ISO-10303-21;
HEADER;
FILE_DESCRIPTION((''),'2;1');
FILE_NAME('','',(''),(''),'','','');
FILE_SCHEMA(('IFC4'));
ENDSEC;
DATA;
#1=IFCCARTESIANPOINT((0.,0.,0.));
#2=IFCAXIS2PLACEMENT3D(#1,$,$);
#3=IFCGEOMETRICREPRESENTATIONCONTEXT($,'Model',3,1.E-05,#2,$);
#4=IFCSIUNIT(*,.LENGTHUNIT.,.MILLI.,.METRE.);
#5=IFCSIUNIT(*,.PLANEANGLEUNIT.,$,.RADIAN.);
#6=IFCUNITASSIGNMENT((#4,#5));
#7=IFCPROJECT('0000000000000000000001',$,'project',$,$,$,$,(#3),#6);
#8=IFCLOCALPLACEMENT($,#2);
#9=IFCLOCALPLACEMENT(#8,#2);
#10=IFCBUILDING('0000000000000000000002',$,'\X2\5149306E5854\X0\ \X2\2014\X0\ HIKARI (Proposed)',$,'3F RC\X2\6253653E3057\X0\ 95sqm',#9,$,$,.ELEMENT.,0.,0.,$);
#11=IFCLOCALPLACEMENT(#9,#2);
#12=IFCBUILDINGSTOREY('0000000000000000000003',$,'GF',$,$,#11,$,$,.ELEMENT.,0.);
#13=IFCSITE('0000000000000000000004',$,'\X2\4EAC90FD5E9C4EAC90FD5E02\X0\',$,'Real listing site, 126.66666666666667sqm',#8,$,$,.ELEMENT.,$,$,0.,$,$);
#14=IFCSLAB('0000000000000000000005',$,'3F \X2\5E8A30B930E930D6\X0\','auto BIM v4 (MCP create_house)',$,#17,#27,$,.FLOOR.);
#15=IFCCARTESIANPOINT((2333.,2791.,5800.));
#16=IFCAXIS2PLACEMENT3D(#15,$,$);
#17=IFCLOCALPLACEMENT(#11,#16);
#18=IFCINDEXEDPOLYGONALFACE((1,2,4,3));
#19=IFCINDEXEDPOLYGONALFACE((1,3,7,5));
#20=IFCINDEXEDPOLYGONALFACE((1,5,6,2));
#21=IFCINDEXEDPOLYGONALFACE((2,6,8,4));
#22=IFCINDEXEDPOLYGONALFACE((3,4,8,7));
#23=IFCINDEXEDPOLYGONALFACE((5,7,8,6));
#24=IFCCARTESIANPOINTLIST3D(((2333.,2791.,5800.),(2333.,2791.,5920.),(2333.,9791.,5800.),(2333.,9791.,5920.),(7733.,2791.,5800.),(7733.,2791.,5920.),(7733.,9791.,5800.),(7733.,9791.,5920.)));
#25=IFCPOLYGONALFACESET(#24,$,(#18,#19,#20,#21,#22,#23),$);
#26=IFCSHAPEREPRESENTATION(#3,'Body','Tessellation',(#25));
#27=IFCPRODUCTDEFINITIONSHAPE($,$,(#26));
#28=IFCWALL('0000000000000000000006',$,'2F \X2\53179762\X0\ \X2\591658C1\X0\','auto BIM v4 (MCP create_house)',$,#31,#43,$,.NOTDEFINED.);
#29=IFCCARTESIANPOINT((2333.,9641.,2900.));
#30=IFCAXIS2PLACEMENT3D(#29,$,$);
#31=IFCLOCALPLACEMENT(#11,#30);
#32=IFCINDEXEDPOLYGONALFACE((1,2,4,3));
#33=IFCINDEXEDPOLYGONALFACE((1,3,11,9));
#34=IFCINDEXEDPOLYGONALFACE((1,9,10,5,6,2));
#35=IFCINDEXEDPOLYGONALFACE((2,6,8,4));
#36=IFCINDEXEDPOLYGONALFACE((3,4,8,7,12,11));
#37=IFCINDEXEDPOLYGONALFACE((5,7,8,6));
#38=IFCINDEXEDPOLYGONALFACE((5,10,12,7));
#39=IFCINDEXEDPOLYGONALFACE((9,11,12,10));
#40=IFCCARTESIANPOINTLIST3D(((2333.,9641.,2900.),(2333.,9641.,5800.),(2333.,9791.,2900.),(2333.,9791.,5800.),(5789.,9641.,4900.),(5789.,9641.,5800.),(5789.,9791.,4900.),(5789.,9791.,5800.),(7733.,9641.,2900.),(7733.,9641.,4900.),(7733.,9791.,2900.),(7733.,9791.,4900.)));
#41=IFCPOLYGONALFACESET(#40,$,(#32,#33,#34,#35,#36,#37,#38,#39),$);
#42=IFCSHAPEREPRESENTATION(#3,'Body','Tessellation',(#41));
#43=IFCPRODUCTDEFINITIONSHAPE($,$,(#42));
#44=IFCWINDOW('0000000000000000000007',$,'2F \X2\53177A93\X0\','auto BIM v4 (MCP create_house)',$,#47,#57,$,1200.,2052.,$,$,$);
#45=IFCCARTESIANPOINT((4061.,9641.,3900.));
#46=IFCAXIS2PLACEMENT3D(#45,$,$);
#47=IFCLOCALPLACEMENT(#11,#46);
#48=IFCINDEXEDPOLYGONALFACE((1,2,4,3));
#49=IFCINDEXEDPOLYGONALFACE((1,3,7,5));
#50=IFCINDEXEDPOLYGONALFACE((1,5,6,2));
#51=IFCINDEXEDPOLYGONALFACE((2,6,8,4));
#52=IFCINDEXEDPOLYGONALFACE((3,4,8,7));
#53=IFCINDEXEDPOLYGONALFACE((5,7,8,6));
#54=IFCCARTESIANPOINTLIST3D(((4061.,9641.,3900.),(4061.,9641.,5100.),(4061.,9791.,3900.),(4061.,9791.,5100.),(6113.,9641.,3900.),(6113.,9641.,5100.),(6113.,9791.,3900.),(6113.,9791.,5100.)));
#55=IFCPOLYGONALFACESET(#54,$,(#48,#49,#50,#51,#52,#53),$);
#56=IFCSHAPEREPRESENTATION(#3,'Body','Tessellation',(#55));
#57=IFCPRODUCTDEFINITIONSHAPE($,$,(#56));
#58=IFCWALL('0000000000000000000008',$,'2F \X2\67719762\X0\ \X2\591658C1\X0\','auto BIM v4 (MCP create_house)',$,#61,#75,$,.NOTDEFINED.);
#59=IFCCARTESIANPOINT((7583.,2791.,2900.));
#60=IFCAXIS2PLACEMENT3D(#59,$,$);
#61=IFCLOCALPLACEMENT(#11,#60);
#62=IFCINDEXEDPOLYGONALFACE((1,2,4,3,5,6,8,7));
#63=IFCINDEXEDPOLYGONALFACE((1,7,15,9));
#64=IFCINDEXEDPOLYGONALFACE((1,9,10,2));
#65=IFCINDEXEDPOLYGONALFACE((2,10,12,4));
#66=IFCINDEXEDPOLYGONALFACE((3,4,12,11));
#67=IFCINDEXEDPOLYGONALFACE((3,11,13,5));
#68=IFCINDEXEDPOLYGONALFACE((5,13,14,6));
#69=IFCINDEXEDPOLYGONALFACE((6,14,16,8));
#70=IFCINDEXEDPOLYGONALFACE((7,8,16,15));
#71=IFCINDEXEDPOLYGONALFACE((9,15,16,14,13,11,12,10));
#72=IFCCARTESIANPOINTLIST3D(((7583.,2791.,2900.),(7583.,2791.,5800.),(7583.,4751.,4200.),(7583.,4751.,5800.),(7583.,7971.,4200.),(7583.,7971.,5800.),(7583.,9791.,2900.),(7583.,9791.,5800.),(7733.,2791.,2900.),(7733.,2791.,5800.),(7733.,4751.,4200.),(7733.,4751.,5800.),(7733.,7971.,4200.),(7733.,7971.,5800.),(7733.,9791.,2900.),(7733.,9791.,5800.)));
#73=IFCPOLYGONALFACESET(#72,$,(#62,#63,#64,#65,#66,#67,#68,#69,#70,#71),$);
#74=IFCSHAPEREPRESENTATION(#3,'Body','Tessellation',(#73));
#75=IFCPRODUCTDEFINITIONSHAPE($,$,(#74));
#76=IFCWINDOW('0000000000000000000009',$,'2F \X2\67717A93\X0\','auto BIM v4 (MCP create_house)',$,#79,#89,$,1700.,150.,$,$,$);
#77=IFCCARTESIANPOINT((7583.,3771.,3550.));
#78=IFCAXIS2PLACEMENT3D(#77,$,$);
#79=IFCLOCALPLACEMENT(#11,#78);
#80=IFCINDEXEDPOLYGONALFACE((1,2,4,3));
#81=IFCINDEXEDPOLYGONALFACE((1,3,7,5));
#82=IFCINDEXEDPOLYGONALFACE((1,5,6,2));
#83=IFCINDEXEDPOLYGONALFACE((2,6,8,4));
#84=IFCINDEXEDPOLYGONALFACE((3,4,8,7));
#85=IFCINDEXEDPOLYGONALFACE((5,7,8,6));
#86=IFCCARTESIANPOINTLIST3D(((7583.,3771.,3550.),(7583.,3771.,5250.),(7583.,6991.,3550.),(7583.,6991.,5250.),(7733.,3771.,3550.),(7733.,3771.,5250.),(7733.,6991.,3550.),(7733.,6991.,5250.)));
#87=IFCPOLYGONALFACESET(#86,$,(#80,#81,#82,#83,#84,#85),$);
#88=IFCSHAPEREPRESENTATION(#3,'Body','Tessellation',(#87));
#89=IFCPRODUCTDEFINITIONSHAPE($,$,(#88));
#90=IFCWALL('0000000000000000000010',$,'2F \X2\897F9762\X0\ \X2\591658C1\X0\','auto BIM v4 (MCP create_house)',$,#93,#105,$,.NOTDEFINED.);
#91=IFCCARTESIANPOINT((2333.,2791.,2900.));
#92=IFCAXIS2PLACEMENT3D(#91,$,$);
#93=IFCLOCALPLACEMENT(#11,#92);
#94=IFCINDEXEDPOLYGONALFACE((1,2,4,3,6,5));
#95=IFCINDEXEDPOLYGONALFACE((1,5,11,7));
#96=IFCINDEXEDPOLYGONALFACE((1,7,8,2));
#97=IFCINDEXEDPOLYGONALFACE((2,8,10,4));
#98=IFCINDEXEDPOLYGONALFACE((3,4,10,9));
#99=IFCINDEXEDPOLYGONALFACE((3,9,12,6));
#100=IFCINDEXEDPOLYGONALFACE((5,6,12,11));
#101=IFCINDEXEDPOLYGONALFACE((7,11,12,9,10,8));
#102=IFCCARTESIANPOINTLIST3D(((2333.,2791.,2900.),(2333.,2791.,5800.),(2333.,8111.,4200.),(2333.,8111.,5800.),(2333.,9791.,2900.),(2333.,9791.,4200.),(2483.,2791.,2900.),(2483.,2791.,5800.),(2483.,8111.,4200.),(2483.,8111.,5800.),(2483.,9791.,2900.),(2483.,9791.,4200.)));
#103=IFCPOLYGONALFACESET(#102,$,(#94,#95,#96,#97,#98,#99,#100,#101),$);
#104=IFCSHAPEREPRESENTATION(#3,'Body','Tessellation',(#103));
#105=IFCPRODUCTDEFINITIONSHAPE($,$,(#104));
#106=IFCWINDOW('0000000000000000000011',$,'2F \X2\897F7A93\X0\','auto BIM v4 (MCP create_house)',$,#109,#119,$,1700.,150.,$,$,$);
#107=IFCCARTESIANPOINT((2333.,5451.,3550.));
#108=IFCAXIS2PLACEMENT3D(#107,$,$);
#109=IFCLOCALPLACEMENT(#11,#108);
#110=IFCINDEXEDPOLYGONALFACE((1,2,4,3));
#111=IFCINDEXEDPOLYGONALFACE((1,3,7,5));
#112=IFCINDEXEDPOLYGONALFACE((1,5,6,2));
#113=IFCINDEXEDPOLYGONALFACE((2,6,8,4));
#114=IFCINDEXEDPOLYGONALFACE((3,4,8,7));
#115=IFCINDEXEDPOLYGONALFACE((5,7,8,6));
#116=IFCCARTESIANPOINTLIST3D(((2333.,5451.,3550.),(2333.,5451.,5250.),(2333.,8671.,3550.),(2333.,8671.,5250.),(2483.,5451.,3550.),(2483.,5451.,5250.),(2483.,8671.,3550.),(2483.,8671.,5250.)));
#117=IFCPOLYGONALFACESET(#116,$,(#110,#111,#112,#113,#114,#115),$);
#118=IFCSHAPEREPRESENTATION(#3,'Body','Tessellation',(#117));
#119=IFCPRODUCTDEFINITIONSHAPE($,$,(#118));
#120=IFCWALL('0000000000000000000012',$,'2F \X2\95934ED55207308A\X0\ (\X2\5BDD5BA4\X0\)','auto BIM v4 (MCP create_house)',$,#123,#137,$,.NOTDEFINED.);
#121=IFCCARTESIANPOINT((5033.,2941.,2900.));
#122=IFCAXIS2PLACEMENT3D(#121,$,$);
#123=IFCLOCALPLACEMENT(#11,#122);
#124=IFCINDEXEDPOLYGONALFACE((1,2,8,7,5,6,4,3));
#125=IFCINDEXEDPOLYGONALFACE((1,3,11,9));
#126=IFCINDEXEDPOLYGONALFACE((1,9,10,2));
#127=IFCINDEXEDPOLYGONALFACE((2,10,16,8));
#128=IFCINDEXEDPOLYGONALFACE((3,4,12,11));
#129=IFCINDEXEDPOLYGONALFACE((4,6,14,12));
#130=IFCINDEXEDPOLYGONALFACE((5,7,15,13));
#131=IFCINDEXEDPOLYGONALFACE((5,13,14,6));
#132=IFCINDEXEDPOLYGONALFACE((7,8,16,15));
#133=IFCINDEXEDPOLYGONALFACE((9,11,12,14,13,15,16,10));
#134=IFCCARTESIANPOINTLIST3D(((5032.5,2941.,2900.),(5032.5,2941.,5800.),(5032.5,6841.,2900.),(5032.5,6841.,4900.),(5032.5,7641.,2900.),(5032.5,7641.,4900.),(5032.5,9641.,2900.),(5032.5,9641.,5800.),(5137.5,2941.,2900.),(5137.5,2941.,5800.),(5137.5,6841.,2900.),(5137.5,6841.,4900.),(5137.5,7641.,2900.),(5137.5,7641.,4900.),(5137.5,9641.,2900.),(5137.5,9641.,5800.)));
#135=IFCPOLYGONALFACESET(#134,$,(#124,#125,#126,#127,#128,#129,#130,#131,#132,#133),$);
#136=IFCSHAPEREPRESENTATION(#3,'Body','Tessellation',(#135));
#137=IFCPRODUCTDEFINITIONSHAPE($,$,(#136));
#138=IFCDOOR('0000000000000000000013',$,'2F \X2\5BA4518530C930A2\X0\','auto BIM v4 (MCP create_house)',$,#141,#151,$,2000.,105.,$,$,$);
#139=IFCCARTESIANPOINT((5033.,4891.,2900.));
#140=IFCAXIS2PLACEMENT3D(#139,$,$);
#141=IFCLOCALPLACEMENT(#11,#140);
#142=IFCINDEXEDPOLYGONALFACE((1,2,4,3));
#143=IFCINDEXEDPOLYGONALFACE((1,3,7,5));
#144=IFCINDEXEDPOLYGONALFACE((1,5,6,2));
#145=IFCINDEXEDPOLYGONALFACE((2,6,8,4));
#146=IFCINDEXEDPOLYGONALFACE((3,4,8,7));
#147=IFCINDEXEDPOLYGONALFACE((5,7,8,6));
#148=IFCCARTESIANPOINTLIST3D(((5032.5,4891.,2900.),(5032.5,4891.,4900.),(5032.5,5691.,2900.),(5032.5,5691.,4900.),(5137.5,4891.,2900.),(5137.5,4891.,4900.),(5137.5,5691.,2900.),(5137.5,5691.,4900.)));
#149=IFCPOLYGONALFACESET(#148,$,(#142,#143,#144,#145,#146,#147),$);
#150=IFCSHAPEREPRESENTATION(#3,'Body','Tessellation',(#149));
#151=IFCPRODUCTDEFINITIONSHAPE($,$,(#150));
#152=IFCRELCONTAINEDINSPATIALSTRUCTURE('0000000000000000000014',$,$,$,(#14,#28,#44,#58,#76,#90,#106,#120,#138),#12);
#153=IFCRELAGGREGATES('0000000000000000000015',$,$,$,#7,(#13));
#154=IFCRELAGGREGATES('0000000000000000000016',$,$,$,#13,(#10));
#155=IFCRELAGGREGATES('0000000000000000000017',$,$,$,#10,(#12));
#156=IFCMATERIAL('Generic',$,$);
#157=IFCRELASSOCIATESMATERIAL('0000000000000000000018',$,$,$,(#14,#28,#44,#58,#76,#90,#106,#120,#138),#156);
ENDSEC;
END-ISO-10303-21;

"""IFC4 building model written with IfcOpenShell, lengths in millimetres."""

from ifc_helpers import new_model, si_unit, frame, frame_2d, origin, place, context, project, spatial, rectangle, extrude, material, element, fill, save


model = new_model("IFC4")

# Units and contexts
model_context = context("Model", 3, precision=1e-05, world=origin())
ifc_project = project(units=[si_unit("LENGTHUNIT", "METRE", prefix="MILLI"), si_unit("PLANEANGLEUNIT", "RADIAN")], contexts=[model_context])

# Site, building, storey
site_placement = place(None, origin())
site = spatial("IfcSite", under=ifc_project, at=site_placement, Name="京都府京都市", ObjectType="Real listing site, 126.66666666666667sqm", CompositionType="ELEMENT", RefElevation=0.0)
building_placement = place(site_placement, origin())
building = spatial("IfcBuilding", under=site, at=building_placement, Name="光の塔 — HIKARI (Proposed)", ObjectType="3F RC打放し 95sqm", CompositionType="ELEMENT", ElevationOfRefHeight=0.0, ElevationOfTerrain=0.0)
storey_placement = place(building_placement, origin())
storey = spatial("IfcBuildingStorey", under=building, at=storey_placement, Name="GF", CompositionType="ELEMENT", Elevation=0.0)

# Slab
ifc_material = material(Name="Generic")
slab_placement = place(storey_placement, frame((2333.0, 2791.0, 5800.0)))
element("IfcSlab", 1, at=slab_placement, inside=storey, material=ifc_material, Name="3F 床スラブ", Description="auto BIM v4 (MCP create_house)", PredefinedType="FLOOR", context=model_context, shape_type="SweptSolid", body=[
    extrude(rectangle(XDim=5400.0, YDim=7000.0, at=frame_2d((2700.0, 3500.0))), frame((2333.0, 2791.0, 5800.0)), (0.0, 0.0, 1.0), 120.0),
])

# Walls, openings, windows
wall_1_placement = place(storey_placement, frame((2333.0, 9641.0, 2900.0)))
wall_1 = element("IfcWall", 2, at=wall_1_placement, inside=storey, material=ifc_material, Name="2F 北面 外壁", Description="auto BIM v4 (MCP create_house)", PredefinedType="NOTDEFINED", context=model_context, shape_type="SweptSolid", body=[
    extrude(rectangle(XDim=5400.0, YDim=150.0, at=frame_2d((2700.0, 75.0))), frame((2333.0, 9641.0, 2900.0)), (0.0, 0.0, 1.0), 2900.0),
])
opening_1_placement = place(storey_placement, frame((4061.0, 9641.0, 3900.0)))
opening_1 = element("IfcOpeningElement", 3, at=opening_1_placement, cuts=wall_1, PredefinedType="NOTDEFINED", context=model_context, shape_type="SweptSolid", body=[
    extrude(rectangle(XDim=2052.0, YDim=150.0, at=frame_2d((1026.0, 75.0))), frame((4061.0, 9641.0, 3900.0)), (0.0, 0.0, 1.0), 1200.0),
])
window_1_placement = place(storey_placement, frame((4061.0, 9641.0, 3900.0)))
window_1 = element("IfcWindow", 4, at=window_1_placement, inside=storey, material=ifc_material, Name="2F 北窓", Description="auto BIM v4 (MCP create_house)", OverallHeight=1200.0, OverallWidth=2052.0, context=model_context, shape_type="SweptSolid", body=[
    extrude(rectangle(XDim=2052.0, YDim=150.0, at=frame_2d((1026.0, 75.0))), frame((4061.0, 9641.0, 3900.0)), (0.0, 0.0, 1.0), 1200.0),
])
fill(opening_1, window_1)
wall_2_placement = place(storey_placement, frame((7583.0, 2791.0, 2900.0)))
wall_2 = element("IfcWall", 5, at=wall_2_placement, inside=storey, material=ifc_material, Name="2F 東面 外壁", Description="auto BIM v4 (MCP create_house)", PredefinedType="NOTDEFINED", context=model_context, shape_type="SweptSolid", body=[
    extrude(rectangle(XDim=150.0, YDim=7000.0, at=frame_2d((75.0, 3500.0))), frame((7583.0, 2791.0, 2900.0)), (0.0, 0.0, 1.0), 2900.0),
])
opening_2_placement = place(storey_placement, frame((7583.0, 3771.0, 3550.0)))
opening_2 = element("IfcOpeningElement", 6, at=opening_2_placement, cuts=wall_2, PredefinedType="NOTDEFINED", context=model_context, shape_type="SweptSolid", body=[
    extrude(rectangle(XDim=150.0, YDim=3220.0, at=frame_2d((75.0, 1610.0))), frame((7583.0, 3771.0, 3550.0)), (0.0, 0.0, 1.0), 1700.0),
])
window_2_placement = place(storey_placement, frame((7583.0, 3771.0, 3550.0)))
window_2 = element("IfcWindow", 7, at=window_2_placement, inside=storey, material=ifc_material, Name="2F 東窓", Description="auto BIM v4 (MCP create_house)", OverallHeight=1700.0, OverallWidth=150.0, context=model_context, shape_type="SweptSolid", body=[
    extrude(rectangle(XDim=150.0, YDim=3220.0, at=frame_2d((75.0, 1610.0))), frame((7583.0, 3771.0, 3550.0)), (0.0, 0.0, 1.0), 1700.0),
])
fill(opening_2, window_2)
wall_3_placement = place(storey_placement, frame((2333.0, 2791.0, 2900.0)))
wall_3 = element("IfcWall", 8, at=wall_3_placement, inside=storey, material=ifc_material, Name="2F 西面 外壁", Description="auto BIM v4 (MCP create_house)", PredefinedType="NOTDEFINED", context=model_context, shape_type="SweptSolid", body=[
    extrude(rectangle(XDim=150.0, YDim=7000.0, at=frame_2d((75.0, 3500.0))), frame((2333.0, 2791.0, 2900.0)), (0.0, 0.0, 1.0), 2900.0),
])
opening_3_placement = place(storey_placement, frame((2333.0, 5451.0, 3550.0)))
opening_3 = element("IfcOpeningElement", 9, at=opening_3_placement, cuts=wall_3, PredefinedType="NOTDEFINED", context=model_context, shape_type="SweptSolid", body=[
    extrude(rectangle(XDim=150.0, YDim=3220.0, at=frame_2d((75.0, 1610.0))), frame((2333.0, 5451.0, 3550.0)), (0.0, 0.0, 1.0), 1700.0),
])
window_3_placement = place(storey_placement, frame((2333.0, 5451.0, 3550.0)))
window_3 = element("IfcWindow", 10, at=window_3_placement, inside=storey, material=ifc_material, Name="2F 西窓", Description="auto BIM v4 (MCP create_house)", OverallHeight=1700.0, OverallWidth=150.0, context=model_context, shape_type="SweptSolid", body=[
    extrude(rectangle(XDim=150.0, YDim=3220.0, at=frame_2d((75.0, 1610.0))), frame((2333.0, 5451.0, 3550.0)), (0.0, 0.0, 1.0), 1700.0),
])
fill(opening_3, window_3)

# Wall, opening, door
wall_4_placement = place(storey_placement, frame((5033.0, 2941.0, 2900.0)))
wall_4 = element("IfcWall", 11, at=wall_4_placement, inside=storey, material=ifc_material, Name="2F 間仕切り (寝室)", Description="auto BIM v4 (MCP create_house)", PredefinedType="NOTDEFINED", context=model_context, shape_type="SweptSolid", body=[
    extrude(rectangle(XDim=105.0, YDim=6700.0, at=frame_2d((52.0, 3350.0))), frame((5033.0, 2941.0, 2900.0)), (0.0, 0.0, 1.0), 2900.0),
])
opening_4_placement = place(storey_placement, frame((5033.0, 4891.0, 2900.0)))
opening_4 = element("IfcOpeningElement", 12, at=opening_4_placement, cuts=wall_4, PredefinedType="NOTDEFINED", context=model_context, shape_type="SweptSolid", body=[
    extrude(rectangle(XDim=105.0, YDim=800.0, at=frame_2d((52.0, 400.0))), frame((5033.0, 4891.0, 2900.0)), (0.0, 0.0, 1.0), 2000.0),
])
door_1_placement = place(storey_placement, frame((5033.0, 4891.0, 2900.0)))
door_1 = element("IfcDoor", 13, at=door_1_placement, inside=storey, material=ifc_material, Name="2F 室内ドア", Description="auto BIM v4 (MCP create_house)", OverallHeight=2000.0, OverallWidth=105.0, context=model_context, shape_type="SweptSolid", body=[
    extrude(rectangle(XDim=105.0, YDim=800.0, at=frame_2d((52.0, 400.0))), frame((5033.0, 4891.0, 2900.0)), (0.0, 0.0, 1.0), 2000.0),
])
fill(opening_4, door_1)

save(model, "model.ifc")
